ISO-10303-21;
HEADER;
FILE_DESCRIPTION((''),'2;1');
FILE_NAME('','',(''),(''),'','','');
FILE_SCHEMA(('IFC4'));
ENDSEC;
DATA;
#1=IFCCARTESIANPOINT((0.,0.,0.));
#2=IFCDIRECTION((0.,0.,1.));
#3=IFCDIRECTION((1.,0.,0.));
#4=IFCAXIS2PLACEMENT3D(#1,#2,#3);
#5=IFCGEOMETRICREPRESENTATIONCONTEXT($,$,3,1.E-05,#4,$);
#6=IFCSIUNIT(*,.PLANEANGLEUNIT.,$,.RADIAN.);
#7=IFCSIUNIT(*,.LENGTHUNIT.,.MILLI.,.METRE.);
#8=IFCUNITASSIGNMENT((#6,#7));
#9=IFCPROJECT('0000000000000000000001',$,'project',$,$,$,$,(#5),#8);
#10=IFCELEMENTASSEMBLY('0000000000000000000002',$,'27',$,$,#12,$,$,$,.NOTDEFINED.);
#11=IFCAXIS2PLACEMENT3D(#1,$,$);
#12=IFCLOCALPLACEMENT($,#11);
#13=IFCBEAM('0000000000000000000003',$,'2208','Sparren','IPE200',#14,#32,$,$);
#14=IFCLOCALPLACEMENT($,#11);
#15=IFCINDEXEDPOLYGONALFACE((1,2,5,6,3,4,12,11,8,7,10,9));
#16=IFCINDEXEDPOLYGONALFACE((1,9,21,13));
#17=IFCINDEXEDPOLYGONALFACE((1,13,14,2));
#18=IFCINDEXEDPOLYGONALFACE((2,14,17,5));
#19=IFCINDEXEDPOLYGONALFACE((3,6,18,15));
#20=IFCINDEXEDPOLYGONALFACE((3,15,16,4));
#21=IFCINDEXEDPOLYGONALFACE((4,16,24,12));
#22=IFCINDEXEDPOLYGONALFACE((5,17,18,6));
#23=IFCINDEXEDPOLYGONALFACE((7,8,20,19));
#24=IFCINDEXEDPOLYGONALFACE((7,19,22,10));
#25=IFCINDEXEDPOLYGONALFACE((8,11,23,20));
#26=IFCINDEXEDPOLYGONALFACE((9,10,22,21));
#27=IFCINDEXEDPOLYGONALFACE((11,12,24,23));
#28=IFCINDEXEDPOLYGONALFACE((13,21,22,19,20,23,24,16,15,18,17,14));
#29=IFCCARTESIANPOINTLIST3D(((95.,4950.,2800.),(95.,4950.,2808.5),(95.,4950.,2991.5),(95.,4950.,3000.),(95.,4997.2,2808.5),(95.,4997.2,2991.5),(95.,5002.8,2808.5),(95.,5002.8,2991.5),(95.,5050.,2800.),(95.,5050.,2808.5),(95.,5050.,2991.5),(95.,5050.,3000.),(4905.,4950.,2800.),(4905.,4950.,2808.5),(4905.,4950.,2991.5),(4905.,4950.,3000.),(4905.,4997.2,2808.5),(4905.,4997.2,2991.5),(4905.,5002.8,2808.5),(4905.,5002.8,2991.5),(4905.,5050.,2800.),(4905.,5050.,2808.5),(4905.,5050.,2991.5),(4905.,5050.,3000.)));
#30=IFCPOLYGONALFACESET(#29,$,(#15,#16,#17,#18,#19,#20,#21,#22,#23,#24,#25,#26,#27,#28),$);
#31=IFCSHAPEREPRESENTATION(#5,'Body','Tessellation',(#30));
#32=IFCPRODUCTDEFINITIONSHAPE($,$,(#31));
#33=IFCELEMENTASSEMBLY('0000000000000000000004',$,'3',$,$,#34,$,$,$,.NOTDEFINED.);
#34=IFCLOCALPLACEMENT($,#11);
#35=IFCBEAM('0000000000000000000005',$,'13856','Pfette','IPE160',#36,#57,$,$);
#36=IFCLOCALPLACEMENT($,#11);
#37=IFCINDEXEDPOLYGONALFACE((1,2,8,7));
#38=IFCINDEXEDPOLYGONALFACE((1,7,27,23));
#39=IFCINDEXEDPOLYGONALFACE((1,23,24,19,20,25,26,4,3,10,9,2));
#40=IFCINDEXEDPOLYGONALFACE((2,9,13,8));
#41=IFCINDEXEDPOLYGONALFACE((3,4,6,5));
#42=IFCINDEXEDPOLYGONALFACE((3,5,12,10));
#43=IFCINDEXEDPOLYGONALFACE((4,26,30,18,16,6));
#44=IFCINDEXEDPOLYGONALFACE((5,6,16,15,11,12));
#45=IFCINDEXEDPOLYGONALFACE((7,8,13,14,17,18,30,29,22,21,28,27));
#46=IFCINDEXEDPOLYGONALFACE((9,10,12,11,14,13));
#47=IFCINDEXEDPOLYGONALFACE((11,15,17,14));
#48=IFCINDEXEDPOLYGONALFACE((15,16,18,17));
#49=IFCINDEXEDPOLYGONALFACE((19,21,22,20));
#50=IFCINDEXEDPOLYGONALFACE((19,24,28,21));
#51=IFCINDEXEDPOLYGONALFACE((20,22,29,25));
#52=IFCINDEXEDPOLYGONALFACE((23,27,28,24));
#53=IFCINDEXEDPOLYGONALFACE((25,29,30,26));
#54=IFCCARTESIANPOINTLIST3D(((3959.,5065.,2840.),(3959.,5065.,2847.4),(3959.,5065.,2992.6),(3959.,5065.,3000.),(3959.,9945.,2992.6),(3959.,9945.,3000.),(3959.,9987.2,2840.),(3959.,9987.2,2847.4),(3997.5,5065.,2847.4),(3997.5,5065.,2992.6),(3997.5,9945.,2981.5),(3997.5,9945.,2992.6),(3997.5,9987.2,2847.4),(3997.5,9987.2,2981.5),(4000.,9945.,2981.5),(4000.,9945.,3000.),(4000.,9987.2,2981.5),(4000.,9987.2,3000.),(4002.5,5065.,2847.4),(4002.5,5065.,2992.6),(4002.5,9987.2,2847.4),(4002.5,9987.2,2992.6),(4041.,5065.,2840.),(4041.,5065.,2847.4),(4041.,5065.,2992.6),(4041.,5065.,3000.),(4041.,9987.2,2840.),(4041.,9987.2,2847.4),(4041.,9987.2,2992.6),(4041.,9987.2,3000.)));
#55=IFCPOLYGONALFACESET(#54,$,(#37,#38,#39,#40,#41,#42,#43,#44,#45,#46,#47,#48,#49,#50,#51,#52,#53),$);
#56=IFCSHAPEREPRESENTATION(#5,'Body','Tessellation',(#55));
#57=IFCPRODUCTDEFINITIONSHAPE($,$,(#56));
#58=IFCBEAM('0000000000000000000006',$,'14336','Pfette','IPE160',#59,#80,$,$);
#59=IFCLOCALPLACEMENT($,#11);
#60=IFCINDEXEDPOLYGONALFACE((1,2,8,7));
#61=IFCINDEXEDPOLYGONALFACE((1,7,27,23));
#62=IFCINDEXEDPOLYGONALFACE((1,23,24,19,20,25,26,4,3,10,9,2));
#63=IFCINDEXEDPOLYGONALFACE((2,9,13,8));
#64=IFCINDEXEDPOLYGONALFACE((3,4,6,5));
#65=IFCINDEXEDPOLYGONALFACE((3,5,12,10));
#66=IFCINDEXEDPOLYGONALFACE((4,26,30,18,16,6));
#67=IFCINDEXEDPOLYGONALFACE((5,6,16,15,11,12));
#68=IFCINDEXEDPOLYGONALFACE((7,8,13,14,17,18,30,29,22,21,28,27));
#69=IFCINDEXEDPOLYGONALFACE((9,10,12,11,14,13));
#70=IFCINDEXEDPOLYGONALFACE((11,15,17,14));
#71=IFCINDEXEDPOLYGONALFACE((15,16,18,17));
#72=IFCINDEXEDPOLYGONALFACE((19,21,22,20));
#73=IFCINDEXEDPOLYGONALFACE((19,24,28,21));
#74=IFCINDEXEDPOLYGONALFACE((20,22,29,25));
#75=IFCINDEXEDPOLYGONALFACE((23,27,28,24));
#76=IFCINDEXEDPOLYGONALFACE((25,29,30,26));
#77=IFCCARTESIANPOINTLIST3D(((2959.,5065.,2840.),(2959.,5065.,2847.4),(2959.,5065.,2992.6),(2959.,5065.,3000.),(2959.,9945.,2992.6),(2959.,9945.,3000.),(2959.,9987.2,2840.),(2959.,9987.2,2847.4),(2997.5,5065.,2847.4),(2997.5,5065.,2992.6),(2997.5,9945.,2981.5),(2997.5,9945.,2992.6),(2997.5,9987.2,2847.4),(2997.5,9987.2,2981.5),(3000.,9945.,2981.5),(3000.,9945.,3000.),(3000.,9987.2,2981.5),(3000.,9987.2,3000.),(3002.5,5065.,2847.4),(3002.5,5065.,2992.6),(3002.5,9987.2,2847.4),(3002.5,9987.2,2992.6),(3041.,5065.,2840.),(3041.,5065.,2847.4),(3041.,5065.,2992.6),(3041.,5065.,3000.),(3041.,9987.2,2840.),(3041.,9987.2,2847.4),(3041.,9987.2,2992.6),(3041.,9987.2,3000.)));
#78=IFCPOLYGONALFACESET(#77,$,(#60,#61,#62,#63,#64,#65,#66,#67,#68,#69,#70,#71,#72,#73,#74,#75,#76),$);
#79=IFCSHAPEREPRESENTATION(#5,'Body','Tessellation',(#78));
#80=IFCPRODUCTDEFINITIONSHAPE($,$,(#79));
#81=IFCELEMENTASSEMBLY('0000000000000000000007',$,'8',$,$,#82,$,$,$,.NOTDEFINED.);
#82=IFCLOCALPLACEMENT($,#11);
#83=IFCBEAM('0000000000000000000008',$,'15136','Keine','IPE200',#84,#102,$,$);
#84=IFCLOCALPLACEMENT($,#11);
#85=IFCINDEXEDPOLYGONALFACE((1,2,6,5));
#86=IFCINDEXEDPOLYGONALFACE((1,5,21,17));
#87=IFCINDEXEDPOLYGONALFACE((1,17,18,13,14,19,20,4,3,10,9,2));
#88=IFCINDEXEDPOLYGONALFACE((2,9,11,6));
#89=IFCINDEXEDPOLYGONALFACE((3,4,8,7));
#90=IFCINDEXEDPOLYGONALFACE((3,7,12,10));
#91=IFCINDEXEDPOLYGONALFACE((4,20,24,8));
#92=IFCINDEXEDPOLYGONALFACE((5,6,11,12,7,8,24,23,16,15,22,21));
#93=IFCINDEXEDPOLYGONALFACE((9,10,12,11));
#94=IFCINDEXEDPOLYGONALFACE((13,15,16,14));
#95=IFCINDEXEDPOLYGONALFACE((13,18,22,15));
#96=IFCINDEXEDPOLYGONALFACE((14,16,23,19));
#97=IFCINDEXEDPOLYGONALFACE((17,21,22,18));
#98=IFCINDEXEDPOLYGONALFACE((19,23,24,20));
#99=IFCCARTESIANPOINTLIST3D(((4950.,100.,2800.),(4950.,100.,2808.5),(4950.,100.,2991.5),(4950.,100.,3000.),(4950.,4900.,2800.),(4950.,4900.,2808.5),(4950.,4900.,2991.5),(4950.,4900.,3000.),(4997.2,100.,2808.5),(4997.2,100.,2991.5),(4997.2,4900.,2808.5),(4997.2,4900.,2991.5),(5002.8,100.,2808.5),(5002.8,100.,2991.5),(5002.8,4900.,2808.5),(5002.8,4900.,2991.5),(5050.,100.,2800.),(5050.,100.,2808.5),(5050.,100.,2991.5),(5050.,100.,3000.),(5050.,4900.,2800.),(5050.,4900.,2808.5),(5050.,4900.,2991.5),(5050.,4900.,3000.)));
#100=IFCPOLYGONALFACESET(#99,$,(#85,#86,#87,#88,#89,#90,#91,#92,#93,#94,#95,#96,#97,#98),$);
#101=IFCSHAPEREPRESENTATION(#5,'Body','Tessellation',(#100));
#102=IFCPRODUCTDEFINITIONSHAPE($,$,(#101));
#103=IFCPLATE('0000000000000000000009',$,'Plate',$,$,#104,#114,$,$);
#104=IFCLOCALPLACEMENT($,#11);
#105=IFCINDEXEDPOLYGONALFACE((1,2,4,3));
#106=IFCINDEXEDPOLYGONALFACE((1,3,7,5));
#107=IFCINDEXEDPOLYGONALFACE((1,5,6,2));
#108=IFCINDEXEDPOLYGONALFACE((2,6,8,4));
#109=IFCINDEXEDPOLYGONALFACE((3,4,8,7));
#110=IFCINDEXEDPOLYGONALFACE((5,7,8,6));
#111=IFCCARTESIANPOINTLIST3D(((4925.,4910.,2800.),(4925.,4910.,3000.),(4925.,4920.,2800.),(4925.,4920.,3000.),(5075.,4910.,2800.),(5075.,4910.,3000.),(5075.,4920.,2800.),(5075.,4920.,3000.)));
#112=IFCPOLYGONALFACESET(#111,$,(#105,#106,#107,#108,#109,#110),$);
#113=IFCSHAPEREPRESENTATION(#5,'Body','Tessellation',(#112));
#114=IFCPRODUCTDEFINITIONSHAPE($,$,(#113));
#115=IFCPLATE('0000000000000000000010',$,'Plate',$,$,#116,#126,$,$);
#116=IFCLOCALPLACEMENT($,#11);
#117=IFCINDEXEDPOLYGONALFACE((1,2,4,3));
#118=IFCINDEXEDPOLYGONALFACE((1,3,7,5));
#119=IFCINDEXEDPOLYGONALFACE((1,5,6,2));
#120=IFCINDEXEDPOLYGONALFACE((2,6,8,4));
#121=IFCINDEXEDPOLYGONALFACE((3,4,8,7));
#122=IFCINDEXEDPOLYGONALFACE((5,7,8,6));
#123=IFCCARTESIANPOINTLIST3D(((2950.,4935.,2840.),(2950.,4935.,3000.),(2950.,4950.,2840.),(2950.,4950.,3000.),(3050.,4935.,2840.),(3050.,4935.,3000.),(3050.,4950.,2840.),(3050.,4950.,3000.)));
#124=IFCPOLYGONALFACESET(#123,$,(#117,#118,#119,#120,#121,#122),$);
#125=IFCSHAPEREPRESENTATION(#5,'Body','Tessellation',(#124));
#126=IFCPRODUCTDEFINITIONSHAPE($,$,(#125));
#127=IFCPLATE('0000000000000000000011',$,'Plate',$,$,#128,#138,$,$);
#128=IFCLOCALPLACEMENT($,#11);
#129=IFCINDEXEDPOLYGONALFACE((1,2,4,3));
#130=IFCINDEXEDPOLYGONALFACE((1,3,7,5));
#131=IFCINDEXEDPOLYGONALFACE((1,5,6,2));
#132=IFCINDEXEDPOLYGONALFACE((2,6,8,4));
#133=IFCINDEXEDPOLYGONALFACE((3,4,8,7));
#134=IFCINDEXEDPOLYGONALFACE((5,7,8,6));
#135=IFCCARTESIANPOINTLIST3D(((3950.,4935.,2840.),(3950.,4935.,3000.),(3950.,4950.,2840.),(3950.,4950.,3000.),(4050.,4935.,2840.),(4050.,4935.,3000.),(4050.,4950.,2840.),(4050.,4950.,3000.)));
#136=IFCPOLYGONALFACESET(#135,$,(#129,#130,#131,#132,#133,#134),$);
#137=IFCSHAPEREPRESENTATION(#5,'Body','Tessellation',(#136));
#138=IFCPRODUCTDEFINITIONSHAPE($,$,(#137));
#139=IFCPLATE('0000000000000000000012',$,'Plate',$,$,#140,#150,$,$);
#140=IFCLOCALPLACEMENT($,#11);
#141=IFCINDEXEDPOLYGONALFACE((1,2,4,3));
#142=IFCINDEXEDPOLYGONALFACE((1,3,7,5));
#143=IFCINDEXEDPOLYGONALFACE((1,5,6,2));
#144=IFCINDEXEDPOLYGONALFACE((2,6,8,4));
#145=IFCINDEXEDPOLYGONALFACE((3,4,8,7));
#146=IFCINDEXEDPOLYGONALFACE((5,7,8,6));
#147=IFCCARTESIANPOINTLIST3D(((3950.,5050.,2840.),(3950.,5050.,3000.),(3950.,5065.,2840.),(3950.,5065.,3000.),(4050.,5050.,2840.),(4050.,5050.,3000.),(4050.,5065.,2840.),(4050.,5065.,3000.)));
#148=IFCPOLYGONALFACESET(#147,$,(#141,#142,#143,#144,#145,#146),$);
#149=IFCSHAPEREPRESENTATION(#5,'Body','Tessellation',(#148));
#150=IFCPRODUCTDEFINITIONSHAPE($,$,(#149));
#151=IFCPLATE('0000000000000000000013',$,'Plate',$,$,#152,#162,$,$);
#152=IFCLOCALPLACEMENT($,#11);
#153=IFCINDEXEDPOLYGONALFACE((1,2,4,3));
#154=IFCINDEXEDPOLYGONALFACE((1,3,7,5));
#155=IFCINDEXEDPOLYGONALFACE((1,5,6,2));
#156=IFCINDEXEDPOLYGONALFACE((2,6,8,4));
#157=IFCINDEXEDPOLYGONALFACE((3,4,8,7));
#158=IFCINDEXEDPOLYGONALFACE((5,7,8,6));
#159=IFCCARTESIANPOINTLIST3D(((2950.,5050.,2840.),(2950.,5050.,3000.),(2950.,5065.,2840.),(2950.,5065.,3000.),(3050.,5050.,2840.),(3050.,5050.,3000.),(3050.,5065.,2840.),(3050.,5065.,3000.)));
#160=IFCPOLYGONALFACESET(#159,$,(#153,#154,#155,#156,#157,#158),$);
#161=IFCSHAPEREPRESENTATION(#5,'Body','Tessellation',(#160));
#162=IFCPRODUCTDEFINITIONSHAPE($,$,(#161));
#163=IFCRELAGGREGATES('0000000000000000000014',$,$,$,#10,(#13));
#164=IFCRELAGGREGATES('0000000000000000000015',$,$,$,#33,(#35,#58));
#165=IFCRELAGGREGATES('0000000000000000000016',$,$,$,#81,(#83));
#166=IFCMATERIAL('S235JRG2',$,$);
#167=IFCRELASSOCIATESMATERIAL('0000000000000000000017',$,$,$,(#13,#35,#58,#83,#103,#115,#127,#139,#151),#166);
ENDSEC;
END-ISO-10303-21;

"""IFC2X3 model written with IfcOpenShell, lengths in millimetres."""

from ifc_helpers import new_model, si_unit, point, frame, origin_with_axes, place, context, project, polyline, line_curve, trimmed, segment, composite_curve, outline, extrude, clip, halfspace, material, element, aggregate, save


model = new_model("IFC2X3")

# Units and contexts
context_of_model = context(None, 3, precision=1e-05, world=origin_with_axes())
ifc_project = project(units=[si_unit("PLANEANGLEUNIT", "RADIAN"), si_unit("LENGTHUNIT", "METRE", prefix="MILLI")], contexts=[context_of_model])

# Element assemblies, beams, openings
assembly_1_placement = place(None, frame((5000.0, 5000.0, 6000.0), z_axis=(0.0, 0.0, 1.0), x_axis=(-1.0, 0.0, 0.0)))
assembly_1 = element("IfcElementAssembly", 1, at=assembly_1_placement, Name="27", PredefinedType="NOTDEFINED")
ifc_material = material(Name="S235JRG2")
placement_1 = place(None, frame((5000.0, 5000.0, 2900.0), z_axis=(0.0, 0.0, 1.0), x_axis=(-1.0, 0.0, 0.0)))
beam_1_placement = place(placement_1, origin_with_axes())
beam_1 = element("IfcBeam", 2, at=beam_1_placement, material=ifc_material, Name="2208", Description="Sparren", ObjectType="IPE200", context=context_of_model, shape_type="Clipping", body=[
    clip(clip(extrude(outline(polyline([(50.0, -100.0), (50.0, -91.5), (2.8, -91.5), (2.8, 91.5), (50.0, 91.5), (50.0, 100.0), (-50.0, 100.0), (-50.0, 91.5), (-2.8, 91.5), (-2.8, -91.5), (-50.0, -91.5), (-50.0, -100.0), (50.0, -100.0), (50.0, -100.0)])), frame((0.0, 0.0, 0.0), z_axis=(1.0, 0.0, 0.0), x_axis=(0.0, 1.0, 0.0)), (0.0, 0.0, 1.0), 5000.0), halfspace(frame((95.0, 0.0, 100.0), z_axis=(-1.0, 0.0, 0.0), x_axis=(0.0, 0.0, -1.0)), False)), halfspace(frame((4905.0, 0.0, 100.0), z_axis=(1.0, 0.0, 0.0), x_axis=(0.0, 0.0, 1.0)), False)),
])
aggregate(assembly_1, [beam_1])
assembly_2_placement = place(None, frame((1000.0, 5002.5, 6000.0), z_axis=(0.0, 0.0, 1.0), x_axis=(0.0, 1.0, 0.0)))
assembly_2 = element("IfcElementAssembly", 3, at=assembly_2_placement, Name="3", PredefinedType="NOTDEFINED")
placement_2 = place(None, frame((4000.0, 5002.5, 2920.0), z_axis=(0.0, 0.0, 1.0), x_axis=(0.0, 1.0, 0.0)))
beam_2_placement = place(placement_2, origin_with_axes())
beam_2 = element("IfcBeam", 4, at=beam_2_placement, material=ifc_material, Name="13856", Description="Pfette", ObjectType="IPE160", context=context_of_model, shape_type="Clipping", body=[
    clip(clip(extrude(outline(polyline([(41.0, -80.0), (41.0, -72.6), (2.5, -72.6), (2.5, 72.6), (41.0, 72.6), (41.0, 80.0), (-41.0, 80.0), (-41.0, 72.6), (-2.5, 72.6), (-2.5, -72.6), (-41.0, -72.6), (-41.0, -80.0), (41.0, -80.0), (41.0, -80.0)])), frame((0.0, 0.0, 0.0), z_axis=(1.0, 0.0, 0.0), x_axis=(0.0, 1.0, 0.0)), (0.0, 0.0, 1.0), 4997.5), halfspace(frame((62.5, 0.0, 80.0), z_axis=(-1.0, 0.0, 0.0), x_axis=(0.0, 0.0, -1.0)), False)), halfspace(frame((4984.7, 0.0, 80.0), z_axis=(1.0, 0.0, 0.0), x_axis=(0.0, 0.0, 1.0)), False)),
])
opening_1_placement = place(beam_2_placement, frame((4942.5, 0.0, 61.5), z_axis=(0.0, 1.0, 0.0), x_axis=(-1.0, 0.0, 0.0)))
element("IfcOpeningElement", 5, at=opening_1_placement, cuts=beam_2, ObjectType="Recess", context=context_of_model, shape_type="SweptSolid", body=[
    extrude(outline(composite_curve([segment(trimmed(line_curve((0.0, 0.0), (0.0, 1.0, 0.0), 18.501), [point((0.0, 0.0))], [point((0.0, 18.5))], True, "CARTESIAN"), True, "CONTINUOUS"), segment(trimmed(line_curve((0.0, 18.5), (-1.0, 0.0, 0.0), 42.201), [point((0.0, 18.5))], [point((-42.2, 18.5))], True, "CARTESIAN"), True, "CONTINUOUS"), segment(trimmed(line_curve((-42.2, 18.5), (0.0, -1.0, 0.0), 18.501), [point((-42.2, 18.5))], [point((-42.2, 0.0))], True, "CARTESIAN"), True, "CONTINUOUS"), segment(trimmed(line_curve((-42.2, 0.0), (1.0, 0.0, 0.0), 42.201), [point((-42.2, 0.0))], [point((0.0, 0.0))], True, "CARTESIAN"), True, "CONTINUOUS")], self_intersect=False)), origin_with_axes(), (0.0, 0.0, 1.0), 3000.0),
])
placement_3 = place(None, frame((3000.0, 5002.5, 2920.0), z_axis=(0.0, 0.0, 1.0), x_axis=(0.0, 1.0, 0.0)))
beam_3_placement = place(placement_3, origin_with_axes())
beam_3 = element("IfcBeam", 6, at=beam_3_placement, material=ifc_material, Name="14336", Description="Pfette", ObjectType="IPE160", context=context_of_model, shape_type="Clipping", body=[
    clip(clip(extrude(outline(polyline([(41.0, -80.0), (41.0, -72.6), (2.5, -72.6), (2.5, 72.6), (41.0, 72.6), (41.0, 80.0), (-41.0, 80.0), (-41.0, 72.6), (-2.5, 72.6), (-2.5, -72.6), (-41.0, -72.6), (-41.0, -80.0), (41.0, -80.0), (41.0, -80.0)])), frame((0.0, 0.0, 0.0), z_axis=(1.0, 0.0, 0.0), x_axis=(0.0, 1.0, 0.0)), (0.0, 0.0, 1.0), 4997.5), halfspace(frame((62.5, 0.0, 80.0), z_axis=(-1.0, 0.0, 0.0), x_axis=(0.0, 0.0, -1.0)), False)), halfspace(frame((4984.7, 0.0, 80.0), z_axis=(1.0, 0.0, 0.0), x_axis=(0.0, 0.0, 1.0)), False)),
])
opening_2_placement = place(beam_3_placement, frame((4942.5, 0.0, 61.5), z_axis=(0.0, 1.0, 0.0), x_axis=(-1.0, 0.0, 0.0)))
element("IfcOpeningElement", 7, at=opening_2_placement, cuts=beam_3, ObjectType="Recess", context=context_of_model, shape_type="SweptSolid", body=[
    extrude(outline(composite_curve([segment(trimmed(line_curve((0.0, 0.0), (0.0, 1.0, 0.0), 18.501), [point((0.0, 0.0))], [point((0.0, 18.5))], True, "CARTESIAN"), True, "CONTINUOUS"), segment(trimmed(line_curve((0.0, 18.5), (-1.0, 0.0, 0.0), 42.201), [point((0.0, 18.5))], [point((-42.2, 18.5))], True, "CARTESIAN"), True, "CONTINUOUS"), segment(trimmed(line_curve((-42.2, 18.5), (0.0, -1.0, 0.0), 18.501), [point((-42.2, 18.5))], [point((-42.2, 0.0))], True, "CARTESIAN"), True, "CONTINUOUS"), segment(trimmed(line_curve((-42.2, 0.0), (1.0, 0.0, 0.0), 42.201), [point((-42.2, 0.0))], [point((0.0, 0.0))], True, "CARTESIAN"), True, "CONTINUOUS")], self_intersect=False)), origin_with_axes(), (0.0, 0.0, 1.0), 3000.0),
])
aggregate(assembly_2, [beam_2, beam_3])

# Element assembly, beam
assembly_3_placement = place(None, frame((0.0, 10000.0, 6000.0), z_axis=(0.0, 0.0, 1.0), x_axis=(0.0, -1.0, 0.0)))
assembly_3 = element("IfcElementAssembly", 8, at=assembly_3_placement, Name="8", PredefinedType="NOTDEFINED")
placement_4 = place(None, frame((5000.0, 5000.0, 2900.0), z_axis=(0.0, 0.0, 1.0), x_axis=(0.0, -1.0, 0.0)))
beam_4_placement = place(placement_4, origin_with_axes())
beam_4 = element("IfcBeam", 9, at=beam_4_placement, material=ifc_material, Name="15136", Description="Keine", ObjectType="IPE200", context=context_of_model, shape_type="Clipping", body=[
    clip(clip(extrude(outline(polyline([(50.0, -100.0), (50.0, -91.5), (2.8, -91.5), (2.8, 91.5), (50.0, 91.5), (50.0, 100.0), (-50.0, 100.0), (-50.0, 91.5), (-2.8, 91.5), (-2.8, -91.5), (-50.0, -91.5), (-50.0, -100.0), (50.0, -100.0), (50.0, -100.0)])), frame((0.0, 0.0, 0.0), z_axis=(1.0, 0.0, 0.0), x_axis=(0.0, 1.0, 0.0)), (0.0, 0.0, 1.0), 5000.0), halfspace(frame((4900.0, 0.0, 100.0), z_axis=(1.0, 0.0, 0.0), x_axis=(0.0, 0.0, 1.0)), False)), halfspace(frame((100.0, 0.0, 100.0), z_axis=(-1.0, 0.0, 0.0), x_axis=(0.0, 0.0, -1.0)), False)),
])
aggregate(assembly_3, [beam_4])

# Plates
placement_5 = place(None, origin_with_axes())
plate_1_placement = place(placement_5, frame((5075.0, 4920.0, 3000.0), z_axis=(0.0, 0.0, -1.0), x_axis=(0.0, -1.0, 0.0)))
element("IfcPlate", 10, at=plate_1_placement, material=ifc_material, Name="Plate", context=context_of_model, shape_type="SweptSolid", body=[
    extrude(outline(polyline([(0.0, 0.0), (150.0, 0.0), (150.0, 200.0), (0.0, 200.0), (0.0, 0.0)])), frame((0.0, 0.0, 0.0), z_axis=(1.0, 0.0, 0.0), x_axis=(0.0, 1.0, 0.0)), (0.0, 0.0, 1.0), 10.0),
])
placement_6 = place(None, origin_with_axes())
plate_2_placement = place(placement_6, frame((2950.0, 4935.0, 2840.0), z_axis=(1.0, 0.0, 0.0), x_axis=(0.0, 1.0, 0.0)))
element("IfcPlate", 11, at=plate_2_placement, material=ifc_material, Name="Plate", context=context_of_model, shape_type="SweptSolid", body=[
    extrude(outline(polyline([(0.0, 0.0), (160.0, 0.0), (160.0, 100.0), (0.0, 100.0), (0.0, 0.0)])), frame((0.0, 0.0, 0.0), z_axis=(1.0, 0.0, 0.0), x_axis=(0.0, 1.0, 0.0)), (0.0, 0.0, 1.0), 15.0),
])
placement_7 = place(None, origin_with_axes())
plate_3_placement = place(placement_7, frame((3950.0, 4935.0, 2840.0), z_axis=(1.0, 0.0, 0.0), x_axis=(0.0, 1.0, 0.0)))
element("IfcPlate", 12, at=plate_3_placement, material=ifc_material, Name="Plate", context=context_of_model, shape_type="SweptSolid", body=[
    extrude(outline(polyline([(0.0, 0.0), (160.0, 0.0), (160.0, 100.0), (0.0, 100.0), (0.0, 0.0)])), frame((0.0, 0.0, 0.0), z_axis=(1.0, 0.0, 0.0), x_axis=(0.0, 1.0, 0.0)), (0.0, 0.0, 1.0), 15.0),
])
placement_8 = place(None, origin_with_axes())
plate_4_placement = place(placement_8, frame((4050.0, 5065.0, 2840.0), z_axis=(-1.0, 0.0, 0.0), x_axis=(0.0, -1.0, 0.0)))
element("IfcPlate", 13, at=plate_4_placement, material=ifc_material, Name="Plate", context=context_of_model, shape_type="SweptSolid", body=[
    extrude(outline(polyline([(0.0, 0.0), (160.0, 0.0), (160.0, 100.0), (0.0, 100.0), (0.0, 0.0)])), frame((0.0, 0.0, 0.0), z_axis=(1.0, 0.0, 0.0), x_axis=(0.0, 1.0, 0.0)), (0.0, 0.0, 1.0), 15.0),
])
placement_9 = place(None, origin_with_axes())
plate_5_placement = place(placement_9, frame((3050.0, 5065.0, 2840.0), z_axis=(-1.0, 0.0, 0.0), x_axis=(0.0, -1.0, 0.0)))
element("IfcPlate", 14, at=plate_5_placement, material=ifc_material, Name="Plate", context=context_of_model, shape_type="SweptSolid", body=[
    extrude(outline(polyline([(0.0, 0.0), (160.0, 0.0), (160.0, 100.0), (0.0, 100.0), (0.0, 0.0)])), frame((0.0, 0.0, 0.0), z_axis=(1.0, 0.0, 0.0), x_axis=(0.0, 1.0, 0.0)), (0.0, 0.0, 1.0), 15.0),
])

save(model, "model.ifc")
